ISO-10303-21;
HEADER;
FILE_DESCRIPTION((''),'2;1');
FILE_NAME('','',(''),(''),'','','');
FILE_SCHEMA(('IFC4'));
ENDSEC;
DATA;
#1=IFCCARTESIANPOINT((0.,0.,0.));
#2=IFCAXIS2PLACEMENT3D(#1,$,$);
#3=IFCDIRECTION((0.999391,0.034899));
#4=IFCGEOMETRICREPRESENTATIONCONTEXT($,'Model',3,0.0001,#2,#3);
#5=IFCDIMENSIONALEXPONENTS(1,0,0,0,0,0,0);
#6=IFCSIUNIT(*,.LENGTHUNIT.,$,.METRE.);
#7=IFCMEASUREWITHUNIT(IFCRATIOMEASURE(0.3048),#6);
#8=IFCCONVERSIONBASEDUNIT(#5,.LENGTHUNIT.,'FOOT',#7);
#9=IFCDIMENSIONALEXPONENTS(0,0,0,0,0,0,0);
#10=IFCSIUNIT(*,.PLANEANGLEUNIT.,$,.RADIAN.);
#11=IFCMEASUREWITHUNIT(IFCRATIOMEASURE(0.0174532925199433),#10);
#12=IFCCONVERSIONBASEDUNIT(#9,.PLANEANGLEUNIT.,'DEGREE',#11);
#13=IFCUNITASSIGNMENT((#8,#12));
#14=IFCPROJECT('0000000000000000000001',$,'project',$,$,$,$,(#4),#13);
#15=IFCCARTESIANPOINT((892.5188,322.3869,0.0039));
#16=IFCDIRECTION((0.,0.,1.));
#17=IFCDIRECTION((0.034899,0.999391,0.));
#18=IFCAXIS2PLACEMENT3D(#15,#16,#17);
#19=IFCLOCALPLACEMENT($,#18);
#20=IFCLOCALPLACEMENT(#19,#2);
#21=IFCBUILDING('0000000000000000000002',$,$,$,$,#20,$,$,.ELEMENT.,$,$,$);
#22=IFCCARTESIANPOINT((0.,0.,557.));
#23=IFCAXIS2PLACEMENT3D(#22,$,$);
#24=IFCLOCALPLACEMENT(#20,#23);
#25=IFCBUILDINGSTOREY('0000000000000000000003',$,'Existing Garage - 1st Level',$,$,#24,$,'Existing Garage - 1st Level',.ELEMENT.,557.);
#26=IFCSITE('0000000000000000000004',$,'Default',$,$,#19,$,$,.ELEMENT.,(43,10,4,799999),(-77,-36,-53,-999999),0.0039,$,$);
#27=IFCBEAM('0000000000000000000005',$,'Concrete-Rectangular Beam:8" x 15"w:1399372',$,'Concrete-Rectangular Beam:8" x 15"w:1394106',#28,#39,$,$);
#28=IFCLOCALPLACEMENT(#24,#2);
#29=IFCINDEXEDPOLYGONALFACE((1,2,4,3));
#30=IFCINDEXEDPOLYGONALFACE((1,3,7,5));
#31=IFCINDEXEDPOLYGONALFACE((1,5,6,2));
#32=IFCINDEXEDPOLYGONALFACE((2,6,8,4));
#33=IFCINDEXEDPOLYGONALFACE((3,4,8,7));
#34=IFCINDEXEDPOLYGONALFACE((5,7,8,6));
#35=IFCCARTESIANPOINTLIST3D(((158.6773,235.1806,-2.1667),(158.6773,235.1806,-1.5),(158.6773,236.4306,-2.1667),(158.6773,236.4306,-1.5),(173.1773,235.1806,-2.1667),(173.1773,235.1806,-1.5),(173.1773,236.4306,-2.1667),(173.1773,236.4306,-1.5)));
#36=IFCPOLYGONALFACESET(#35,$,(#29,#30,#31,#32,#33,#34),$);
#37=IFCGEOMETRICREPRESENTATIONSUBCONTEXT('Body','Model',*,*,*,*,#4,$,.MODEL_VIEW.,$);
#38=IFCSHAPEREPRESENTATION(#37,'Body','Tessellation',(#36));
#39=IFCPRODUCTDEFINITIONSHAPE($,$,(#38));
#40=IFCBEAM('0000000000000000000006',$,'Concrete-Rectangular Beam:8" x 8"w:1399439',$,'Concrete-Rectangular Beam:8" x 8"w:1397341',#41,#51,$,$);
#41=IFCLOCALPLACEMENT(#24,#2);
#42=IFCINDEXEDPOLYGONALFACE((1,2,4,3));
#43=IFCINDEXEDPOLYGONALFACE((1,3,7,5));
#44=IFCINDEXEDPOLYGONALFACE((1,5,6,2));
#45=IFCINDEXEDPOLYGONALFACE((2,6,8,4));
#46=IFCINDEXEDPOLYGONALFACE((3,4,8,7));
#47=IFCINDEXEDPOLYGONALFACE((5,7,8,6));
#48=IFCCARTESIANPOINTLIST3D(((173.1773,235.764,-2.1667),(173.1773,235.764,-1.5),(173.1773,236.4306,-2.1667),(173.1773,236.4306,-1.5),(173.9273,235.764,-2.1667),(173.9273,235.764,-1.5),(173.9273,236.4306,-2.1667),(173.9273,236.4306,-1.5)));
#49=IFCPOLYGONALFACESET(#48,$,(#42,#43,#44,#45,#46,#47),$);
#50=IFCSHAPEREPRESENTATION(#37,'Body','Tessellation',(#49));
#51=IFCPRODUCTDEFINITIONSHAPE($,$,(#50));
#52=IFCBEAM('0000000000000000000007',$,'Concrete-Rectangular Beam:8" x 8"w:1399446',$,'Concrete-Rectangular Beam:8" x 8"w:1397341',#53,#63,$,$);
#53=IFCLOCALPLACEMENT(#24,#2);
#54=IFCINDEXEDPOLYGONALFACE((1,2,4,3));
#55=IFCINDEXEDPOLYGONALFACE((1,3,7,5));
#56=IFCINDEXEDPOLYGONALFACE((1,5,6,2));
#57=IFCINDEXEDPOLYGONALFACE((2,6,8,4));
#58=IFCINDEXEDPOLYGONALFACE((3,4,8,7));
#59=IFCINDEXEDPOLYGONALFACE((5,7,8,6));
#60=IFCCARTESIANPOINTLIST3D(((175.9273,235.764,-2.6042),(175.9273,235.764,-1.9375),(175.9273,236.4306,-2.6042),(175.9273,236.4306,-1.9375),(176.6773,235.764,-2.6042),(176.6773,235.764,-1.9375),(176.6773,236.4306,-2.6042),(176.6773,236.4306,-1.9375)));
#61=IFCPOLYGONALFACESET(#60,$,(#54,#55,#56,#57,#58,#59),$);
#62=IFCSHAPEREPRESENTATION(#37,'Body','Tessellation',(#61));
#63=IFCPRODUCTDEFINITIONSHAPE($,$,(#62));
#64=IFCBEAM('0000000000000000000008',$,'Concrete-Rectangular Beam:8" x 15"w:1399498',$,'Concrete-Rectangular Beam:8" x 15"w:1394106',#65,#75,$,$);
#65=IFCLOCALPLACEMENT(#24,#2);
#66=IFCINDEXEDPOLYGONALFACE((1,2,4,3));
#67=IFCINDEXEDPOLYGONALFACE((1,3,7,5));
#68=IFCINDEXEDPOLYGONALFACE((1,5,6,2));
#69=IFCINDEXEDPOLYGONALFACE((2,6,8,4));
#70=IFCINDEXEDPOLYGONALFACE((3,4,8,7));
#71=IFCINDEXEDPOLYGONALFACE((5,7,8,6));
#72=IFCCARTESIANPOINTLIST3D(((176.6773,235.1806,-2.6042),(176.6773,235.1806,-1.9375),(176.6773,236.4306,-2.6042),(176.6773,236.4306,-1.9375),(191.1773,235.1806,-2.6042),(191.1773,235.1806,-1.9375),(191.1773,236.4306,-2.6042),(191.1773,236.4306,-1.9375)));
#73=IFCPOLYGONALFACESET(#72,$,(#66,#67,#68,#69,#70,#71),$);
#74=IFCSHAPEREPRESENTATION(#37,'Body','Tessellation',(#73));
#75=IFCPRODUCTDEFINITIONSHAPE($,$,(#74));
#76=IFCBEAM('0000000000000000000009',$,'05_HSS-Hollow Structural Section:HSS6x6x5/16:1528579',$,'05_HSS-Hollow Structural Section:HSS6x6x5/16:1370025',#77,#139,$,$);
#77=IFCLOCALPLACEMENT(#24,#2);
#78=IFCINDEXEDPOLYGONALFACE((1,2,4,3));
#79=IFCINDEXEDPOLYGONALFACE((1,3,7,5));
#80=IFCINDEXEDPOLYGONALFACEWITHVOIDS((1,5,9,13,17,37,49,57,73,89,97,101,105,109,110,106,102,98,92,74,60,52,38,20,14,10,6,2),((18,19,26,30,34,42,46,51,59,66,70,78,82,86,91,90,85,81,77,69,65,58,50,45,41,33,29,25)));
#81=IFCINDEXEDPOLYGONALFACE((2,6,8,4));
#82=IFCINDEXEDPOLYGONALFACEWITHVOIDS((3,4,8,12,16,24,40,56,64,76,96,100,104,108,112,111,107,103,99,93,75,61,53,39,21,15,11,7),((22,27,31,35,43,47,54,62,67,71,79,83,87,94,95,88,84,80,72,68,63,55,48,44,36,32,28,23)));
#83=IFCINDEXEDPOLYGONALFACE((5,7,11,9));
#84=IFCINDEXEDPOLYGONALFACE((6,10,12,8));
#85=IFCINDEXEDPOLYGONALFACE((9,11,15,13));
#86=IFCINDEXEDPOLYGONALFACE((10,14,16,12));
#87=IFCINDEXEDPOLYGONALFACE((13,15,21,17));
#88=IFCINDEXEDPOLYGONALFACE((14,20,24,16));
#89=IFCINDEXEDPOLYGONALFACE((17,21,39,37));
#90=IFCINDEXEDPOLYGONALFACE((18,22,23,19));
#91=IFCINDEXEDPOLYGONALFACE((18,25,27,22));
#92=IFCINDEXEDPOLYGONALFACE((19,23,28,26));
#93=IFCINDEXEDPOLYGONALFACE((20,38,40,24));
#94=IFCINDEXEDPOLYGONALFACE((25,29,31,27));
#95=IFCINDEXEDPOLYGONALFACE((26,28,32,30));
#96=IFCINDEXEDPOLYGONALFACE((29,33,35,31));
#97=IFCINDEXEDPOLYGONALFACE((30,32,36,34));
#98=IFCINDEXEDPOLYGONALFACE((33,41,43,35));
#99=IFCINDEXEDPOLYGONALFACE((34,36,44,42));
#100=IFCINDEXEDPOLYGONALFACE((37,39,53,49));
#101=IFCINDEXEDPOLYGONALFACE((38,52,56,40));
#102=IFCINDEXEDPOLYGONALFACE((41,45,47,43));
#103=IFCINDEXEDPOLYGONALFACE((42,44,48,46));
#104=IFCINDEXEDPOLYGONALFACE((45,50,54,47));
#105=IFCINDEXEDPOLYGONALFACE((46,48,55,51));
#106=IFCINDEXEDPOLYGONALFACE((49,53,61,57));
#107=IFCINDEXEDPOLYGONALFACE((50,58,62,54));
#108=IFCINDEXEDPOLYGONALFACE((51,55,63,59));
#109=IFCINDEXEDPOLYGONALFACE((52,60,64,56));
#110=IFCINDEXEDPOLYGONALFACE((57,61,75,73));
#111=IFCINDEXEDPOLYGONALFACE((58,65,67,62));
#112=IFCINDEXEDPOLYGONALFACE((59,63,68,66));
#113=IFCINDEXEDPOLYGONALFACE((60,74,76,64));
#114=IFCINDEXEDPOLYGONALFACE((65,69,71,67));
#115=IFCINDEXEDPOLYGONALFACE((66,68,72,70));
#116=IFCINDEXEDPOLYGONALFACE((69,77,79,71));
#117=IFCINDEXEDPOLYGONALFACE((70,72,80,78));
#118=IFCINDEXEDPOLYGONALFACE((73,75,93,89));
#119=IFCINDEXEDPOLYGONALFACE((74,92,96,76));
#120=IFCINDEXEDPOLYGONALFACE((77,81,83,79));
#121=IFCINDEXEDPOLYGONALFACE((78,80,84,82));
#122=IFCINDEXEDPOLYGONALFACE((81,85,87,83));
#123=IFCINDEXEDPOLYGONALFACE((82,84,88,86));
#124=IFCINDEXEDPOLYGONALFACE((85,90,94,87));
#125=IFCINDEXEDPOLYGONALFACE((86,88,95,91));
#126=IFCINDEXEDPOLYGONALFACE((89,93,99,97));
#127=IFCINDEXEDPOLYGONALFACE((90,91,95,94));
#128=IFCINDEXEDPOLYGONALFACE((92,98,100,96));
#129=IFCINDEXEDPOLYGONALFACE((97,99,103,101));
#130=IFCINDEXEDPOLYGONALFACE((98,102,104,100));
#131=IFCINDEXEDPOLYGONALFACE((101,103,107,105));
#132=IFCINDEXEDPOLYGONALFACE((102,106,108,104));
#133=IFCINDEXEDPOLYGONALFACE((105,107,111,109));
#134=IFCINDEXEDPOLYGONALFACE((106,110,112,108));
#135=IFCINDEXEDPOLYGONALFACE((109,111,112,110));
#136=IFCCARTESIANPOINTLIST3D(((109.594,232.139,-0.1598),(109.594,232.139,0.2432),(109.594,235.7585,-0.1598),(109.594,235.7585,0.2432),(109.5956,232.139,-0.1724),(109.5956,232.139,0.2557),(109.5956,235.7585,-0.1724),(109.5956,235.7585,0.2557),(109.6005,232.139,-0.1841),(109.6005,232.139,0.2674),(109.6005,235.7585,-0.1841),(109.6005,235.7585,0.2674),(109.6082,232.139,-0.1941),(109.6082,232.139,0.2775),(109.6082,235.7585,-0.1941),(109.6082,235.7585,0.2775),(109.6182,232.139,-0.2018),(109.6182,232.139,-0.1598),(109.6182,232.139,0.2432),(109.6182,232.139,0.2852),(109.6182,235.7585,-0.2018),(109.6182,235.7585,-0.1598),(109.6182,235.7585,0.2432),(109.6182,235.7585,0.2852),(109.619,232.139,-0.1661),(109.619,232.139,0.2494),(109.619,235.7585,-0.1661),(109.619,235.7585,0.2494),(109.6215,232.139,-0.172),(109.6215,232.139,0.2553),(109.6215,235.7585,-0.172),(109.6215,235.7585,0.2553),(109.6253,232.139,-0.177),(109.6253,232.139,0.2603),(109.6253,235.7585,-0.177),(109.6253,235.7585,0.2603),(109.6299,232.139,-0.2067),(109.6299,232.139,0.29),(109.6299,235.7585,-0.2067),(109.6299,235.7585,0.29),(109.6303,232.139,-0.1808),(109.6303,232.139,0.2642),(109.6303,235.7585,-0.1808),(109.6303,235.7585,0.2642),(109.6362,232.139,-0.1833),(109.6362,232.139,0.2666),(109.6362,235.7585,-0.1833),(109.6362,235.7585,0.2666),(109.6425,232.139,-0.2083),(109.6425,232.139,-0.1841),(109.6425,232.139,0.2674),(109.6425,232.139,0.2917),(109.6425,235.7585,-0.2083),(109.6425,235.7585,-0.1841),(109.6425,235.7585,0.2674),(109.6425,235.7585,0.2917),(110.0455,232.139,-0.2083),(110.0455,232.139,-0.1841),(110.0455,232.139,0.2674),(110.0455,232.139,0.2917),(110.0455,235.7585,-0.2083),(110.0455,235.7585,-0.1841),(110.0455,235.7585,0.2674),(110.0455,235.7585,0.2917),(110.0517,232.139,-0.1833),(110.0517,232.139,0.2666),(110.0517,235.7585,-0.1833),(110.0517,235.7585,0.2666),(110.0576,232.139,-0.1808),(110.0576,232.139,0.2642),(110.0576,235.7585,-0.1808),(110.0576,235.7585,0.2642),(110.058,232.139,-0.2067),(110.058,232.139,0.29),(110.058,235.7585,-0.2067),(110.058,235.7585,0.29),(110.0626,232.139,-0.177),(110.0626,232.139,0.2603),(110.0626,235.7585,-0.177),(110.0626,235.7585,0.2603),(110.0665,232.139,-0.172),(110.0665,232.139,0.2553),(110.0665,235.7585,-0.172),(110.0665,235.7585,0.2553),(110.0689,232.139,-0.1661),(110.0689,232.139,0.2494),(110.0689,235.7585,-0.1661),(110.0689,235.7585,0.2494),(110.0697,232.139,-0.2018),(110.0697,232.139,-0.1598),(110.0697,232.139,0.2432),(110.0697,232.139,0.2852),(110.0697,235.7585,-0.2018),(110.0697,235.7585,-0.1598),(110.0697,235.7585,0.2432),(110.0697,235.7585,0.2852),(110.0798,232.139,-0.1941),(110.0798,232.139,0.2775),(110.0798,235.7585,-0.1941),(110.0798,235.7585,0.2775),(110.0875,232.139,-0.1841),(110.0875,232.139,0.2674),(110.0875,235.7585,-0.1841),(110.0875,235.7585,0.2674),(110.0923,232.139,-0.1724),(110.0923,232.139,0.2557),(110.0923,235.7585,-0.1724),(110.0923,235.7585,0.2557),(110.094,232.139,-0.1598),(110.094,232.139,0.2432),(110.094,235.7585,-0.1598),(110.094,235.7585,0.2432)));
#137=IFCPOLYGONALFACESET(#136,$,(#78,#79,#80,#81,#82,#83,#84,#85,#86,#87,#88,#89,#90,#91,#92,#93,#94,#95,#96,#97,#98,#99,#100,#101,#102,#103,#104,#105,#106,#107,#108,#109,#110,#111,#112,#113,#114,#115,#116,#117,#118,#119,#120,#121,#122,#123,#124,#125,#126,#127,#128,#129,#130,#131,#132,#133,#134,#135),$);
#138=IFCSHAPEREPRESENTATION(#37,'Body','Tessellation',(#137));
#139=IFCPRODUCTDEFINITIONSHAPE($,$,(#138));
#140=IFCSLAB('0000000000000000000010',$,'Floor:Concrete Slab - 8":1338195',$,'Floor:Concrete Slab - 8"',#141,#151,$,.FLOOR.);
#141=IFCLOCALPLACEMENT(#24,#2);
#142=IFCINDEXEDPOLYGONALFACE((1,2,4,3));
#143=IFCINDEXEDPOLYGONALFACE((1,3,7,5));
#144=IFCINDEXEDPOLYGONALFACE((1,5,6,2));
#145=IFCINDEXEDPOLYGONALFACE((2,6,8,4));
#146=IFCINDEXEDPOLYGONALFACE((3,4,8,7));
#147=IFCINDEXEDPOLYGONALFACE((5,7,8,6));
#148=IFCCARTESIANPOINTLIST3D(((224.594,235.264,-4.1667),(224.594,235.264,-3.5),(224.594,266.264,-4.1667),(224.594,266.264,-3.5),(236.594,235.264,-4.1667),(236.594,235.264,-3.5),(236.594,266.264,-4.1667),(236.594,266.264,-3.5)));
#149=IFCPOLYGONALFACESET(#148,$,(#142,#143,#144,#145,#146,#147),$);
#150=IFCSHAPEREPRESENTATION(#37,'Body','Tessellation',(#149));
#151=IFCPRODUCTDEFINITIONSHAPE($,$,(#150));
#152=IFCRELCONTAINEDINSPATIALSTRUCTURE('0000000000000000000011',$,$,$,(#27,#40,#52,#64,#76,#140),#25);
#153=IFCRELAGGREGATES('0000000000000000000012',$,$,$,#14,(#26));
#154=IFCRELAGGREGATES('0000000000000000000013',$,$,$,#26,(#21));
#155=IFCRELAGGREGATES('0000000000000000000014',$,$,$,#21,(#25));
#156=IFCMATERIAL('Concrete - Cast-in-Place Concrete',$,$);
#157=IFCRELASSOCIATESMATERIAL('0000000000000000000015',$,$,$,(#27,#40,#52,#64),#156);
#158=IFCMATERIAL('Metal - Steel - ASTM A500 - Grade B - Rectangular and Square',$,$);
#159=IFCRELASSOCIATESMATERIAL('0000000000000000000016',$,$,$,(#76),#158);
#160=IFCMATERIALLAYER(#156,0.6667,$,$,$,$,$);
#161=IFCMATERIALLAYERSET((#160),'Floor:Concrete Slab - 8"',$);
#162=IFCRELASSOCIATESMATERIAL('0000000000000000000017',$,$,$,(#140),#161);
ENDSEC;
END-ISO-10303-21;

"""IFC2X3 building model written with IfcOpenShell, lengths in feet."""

from ifc_helpers import new_model, entity, si_unit, converted_unit, direction, frame, frame_2d, origin, origin_2d_with_axis, place, context, subcontext, project, spatial, polyline, circle_curve, parameter, trimmed, segment, composite_curve, rectangle, outline, extrude, material, layer, layer_set, layer_usage, element, save


model = new_model("IFC2X3")

# Units and contexts
model_context = context("Model", 3, precision=0.0001, world=origin(), true_north=direction((0.999391, 0.034899)))
body_context = subcontext(model_context, "Body", "Model", "MODEL_VIEW")
ifc_project = project(units=[converted_unit("LENGTHUNIT", "FOOT", entity("IfcRatioMeasure", 0.3048), si_unit("LENGTHUNIT", "METRE"), dimensions=[1, 0, 0, 0, 0, 0, 0]), converted_unit("PLANEANGLEUNIT", "DEGREE", entity("IfcRatioMeasure", 0.0174532925199433), si_unit("PLANEANGLEUNIT", "RADIAN"), dimensions=[0, 0, 0, 0, 0, 0, 0])], contexts=[model_context])

# Site, building, storey
site_placement = place(None, frame((892.5188, 322.3869, 0.0039), z_axis=(0.0, 0.0, 1.0), x_axis=(0.034899, 0.999391, 0.0)))
site = spatial("IfcSite", under=ifc_project, at=site_placement, Name="Default", CompositionType="ELEMENT", RefLatitude=(43, 10, 4, 799999), RefLongitude=(-77, -36, -53, -999999), RefElevation=0.0039)
building_placement = place(site_placement, origin())
building = spatial("IfcBuilding", under=site, at=building_placement, CompositionType="ELEMENT")
storey_placement = place(building_placement, frame((0.0, 0.0, 557.0)))
storey = spatial("IfcBuildingStorey", under=building, at=storey_placement, Name="Existing Garage - 1st Level", LongName="Existing Garage - 1st Level", CompositionType="ELEMENT", Elevation=557.0)

# Beams
ifc_material_1 = material(Name="Metal - Steel - ASTM A500 - Grade B - Rectangular and Square")
ifc_material_2 = material(Name="Concrete - Cast-in-Place Concrete")
beam_1_placement = place(storey_placement, frame((158.6773, 235.8056, -1.5)))
element("IfcBeam", 1, at=beam_1_placement, inside=storey, material=ifc_material_2, Name="Concrete-Rectangular Beam:8\" x 15\"w:1399372", ObjectType="Concrete-Rectangular Beam:8\" x 15\"w:1394106", context=body_context, shape_type="SweptSolid", body=[
    extrude(rectangle(XDim=0.6667, YDim=1.25, at=frame_2d((0.0, 0.0), x_axis=(1.0, 0.0))), frame((0.0, 0.0, -0.3333), z_axis=(1.0, 0.0, 0.0), x_axis=(0.0, 0.0, -1.0)), (0.0, 0.0, 1.0), 14.5),
])
beam_2_placement = place(storey_placement, frame((173.1773, 236.0973, -1.5)))
element("IfcBeam", 2, at=beam_2_placement, inside=storey, material=ifc_material_2, Name="Concrete-Rectangular Beam:8\" x 8\"w:1399439", ObjectType="Concrete-Rectangular Beam:8\" x 8\"w:1397341", context=body_context, shape_type="SweptSolid", body=[
    extrude(rectangle(XDim=0.6667, YDim=0.6667, at=origin_2d_with_axis()), frame((0.0, 0.0, -0.3333), z_axis=(1.0, 0.0, 0.0), x_axis=(0.0, 0.0, -1.0)), (0.0, 0.0, 1.0), 0.75),
])
beam_3_placement = place(storey_placement, frame((176.6773, 236.0973, -1.9375), z_axis=(0.0, 0.0, 1.0), x_axis=(-1.0, 0.0, 0.0)))
element("IfcBeam", 3, at=beam_3_placement, inside=storey, material=ifc_material_2, Name="Concrete-Rectangular Beam:8\" x 8\"w:1399446", ObjectType="Concrete-Rectangular Beam:8\" x 8\"w:1397341", context=body_context, shape_type="SweptSolid", body=[
    extrude(rectangle(XDim=0.6667, YDim=0.6667, at=frame_2d((0.0, 0.0), x_axis=(1.0, 0.0))), frame((0.0, 0.0, -0.3333), z_axis=(1.0, 0.0, 0.0), x_axis=(0.0, 0.0, -1.0)), (0.0, 0.0, 1.0), 0.75),
])
beam_4_placement = place(storey_placement, frame((191.1773, 235.8056, -1.9375), z_axis=(0.0, 0.0, 1.0), x_axis=(-1.0, 0.0, 0.0)))
element("IfcBeam", 4, at=beam_4_placement, inside=storey, material=ifc_material_2, Name="Concrete-Rectangular Beam:8\" x 15\"w:1399498", ObjectType="Concrete-Rectangular Beam:8\" x 15\"w:1394106", context=body_context, shape_type="SweptSolid", body=[
    extrude(rectangle(XDim=0.6667, YDim=1.25, at=frame_2d((0.0, 0.0), x_axis=(1.0, 0.0))), frame((0.0, 0.0, -0.3333), z_axis=(1.0, 0.0, 0.0), x_axis=(0.0, 0.0, -1.0)), (0.0, 0.0, 1.0), 14.5),
])
beam_5_placement = place(storey_placement, frame((109.844, 231.8473, 0.2917), z_axis=(0.0, 0.0, 1.0), x_axis=(0.0, 1.0, 0.0)))
element("IfcBeam", 5, at=beam_5_placement, inside=storey, material=ifc_material_1, Name="05_HSS-Hollow Structural Section:HSS6x6x5/16:1528579", ObjectType="05_HSS-Hollow Structural Section:HSS6x6x5/16:1370025", context=body_context, shape_type="SweptSolid", body=[
    extrude(outline(composite_curve([segment(trimmed(circle_curve(frame_2d((-0.2015, -0.2015), x_axis=(1.0, 0.0)), 0.0485), [parameter(180.0)], [parameter(270.0)], True, "PARAMETER"), True, "CONTINUOUS"), segment(polyline([(-0.2015, -0.25), (0.2015, -0.25)]), True, "CONTINUOUS"), segment(trimmed(circle_curve(frame_2d((0.2015, -0.2015), x_axis=(1.0, 0.0)), 0.0485), [parameter(270.0)], [parameter(0.0)], True, "PARAMETER"), True, "CONTINUOUS"), segment(polyline([(0.25, -0.2015), (0.25, 0.2015)]), True, "CONTINUOUS"), segment(trimmed(circle_curve(frame_2d((0.2015, 0.2015), x_axis=(1.0, 0.0)), 0.0485), [parameter(360.0)], [parameter(90.0)], True, "PARAMETER"), True, "CONTINUOUS"), segment(polyline([(0.2015, 0.25), (-0.2015, 0.25)]), True, "CONTINUOUS"), segment(trimmed(circle_curve(frame_2d((-0.2015, 0.2015), x_axis=(1.0, 0.0)), 0.0485), [parameter(90.0)], [parameter(180.0)], True, "PARAMETER"), True, "CONTINUOUS"), segment(polyline([(-0.25, 0.2015), (-0.25, -0.2015)]), True, "CONTINUOUS")], self_intersect=False), holes=[composite_curve([segment(polyline([(0.2015, -0.2257), (-0.2015, -0.2257)]), True, "CONTINUOUS"), segment(trimmed(circle_curve(frame_2d((-0.2015, -0.2015), x_axis=(1.0, 0.0)), 0.0243), [parameter(180.0)], [parameter(270.0)], True, "PARAMETER"), False, "CONTINUOUS"), segment(polyline([(-0.2257, -0.2015), (-0.2257, 0.2015)]), True, "CONTINUOUS"), segment(trimmed(circle_curve(frame_2d((-0.2015, 0.2015), x_axis=(1.0, 0.0)), 0.0243), [parameter(90.0)], [parameter(180.0)], True, "PARAMETER"), False, "CONTINUOUS"), segment(polyline([(-0.2015, 0.2258), (0.2015, 0.2258)]), True, "CONTINUOUS"), segment(trimmed(circle_curve(frame_2d((0.2015, 0.2015), x_axis=(1.0, 0.0)), 0.0243), [parameter(0.0)], [parameter(90.0)], True, "PARAMETER"), False, "CONTINUOUS"), segment(polyline([(0.2258, 0.2015), (0.2258, -0.2015)]), True, "CONTINUOUS"), segment(trimmed(circle_curve(frame_2d((0.2015, -0.2015), x_axis=(1.0, 0.0)), 0.0243), [parameter(270.0)], [parameter(0.0)], True, "PARAMETER"), False, "CONTINUOUS")], self_intersect=False)]), frame((0.2917, 0.0, -0.25), z_axis=(1.0, 0.0, 0.0), x_axis=(0.0, -1.0, 0.0)), (0.0, 0.0, 1.0), 3.6195),
])

# Slab
ifc_layer_1 = layer(ifc_material_2, 0.6667)
ifc_layer_set_1 = layer_set([ifc_layer_1], Name="Floor:Concrete Slab - 8\"")
ifc_layer_usage_1 = layer_usage(ifc_layer_set_1, "AXIS3", "POSITIVE", 0.0)
slab_1_placement = place(storey_placement, origin())
element("IfcSlab", 6, at=slab_1_placement, inside=storey, material=ifc_layer_usage_1, Name="Floor:Concrete Slab - 8\":1338195", ObjectType="Floor:Concrete Slab - 8\"", PredefinedType="FLOOR", context=body_context, shape_type="SweptSolid", body=[
    extrude(rectangle(XDim=31.0, YDim=12.0, at=frame_2d((0.0, 0.0), x_axis=(1.0, 0.0))), frame((230.594, 250.764, -3.5), z_axis=(0.0, 0.0, -1.0), x_axis=(0.0, 1.0, 0.0)), (0.0, 0.0, 1.0), 0.6667),
])

save(model, "model.ifc")
